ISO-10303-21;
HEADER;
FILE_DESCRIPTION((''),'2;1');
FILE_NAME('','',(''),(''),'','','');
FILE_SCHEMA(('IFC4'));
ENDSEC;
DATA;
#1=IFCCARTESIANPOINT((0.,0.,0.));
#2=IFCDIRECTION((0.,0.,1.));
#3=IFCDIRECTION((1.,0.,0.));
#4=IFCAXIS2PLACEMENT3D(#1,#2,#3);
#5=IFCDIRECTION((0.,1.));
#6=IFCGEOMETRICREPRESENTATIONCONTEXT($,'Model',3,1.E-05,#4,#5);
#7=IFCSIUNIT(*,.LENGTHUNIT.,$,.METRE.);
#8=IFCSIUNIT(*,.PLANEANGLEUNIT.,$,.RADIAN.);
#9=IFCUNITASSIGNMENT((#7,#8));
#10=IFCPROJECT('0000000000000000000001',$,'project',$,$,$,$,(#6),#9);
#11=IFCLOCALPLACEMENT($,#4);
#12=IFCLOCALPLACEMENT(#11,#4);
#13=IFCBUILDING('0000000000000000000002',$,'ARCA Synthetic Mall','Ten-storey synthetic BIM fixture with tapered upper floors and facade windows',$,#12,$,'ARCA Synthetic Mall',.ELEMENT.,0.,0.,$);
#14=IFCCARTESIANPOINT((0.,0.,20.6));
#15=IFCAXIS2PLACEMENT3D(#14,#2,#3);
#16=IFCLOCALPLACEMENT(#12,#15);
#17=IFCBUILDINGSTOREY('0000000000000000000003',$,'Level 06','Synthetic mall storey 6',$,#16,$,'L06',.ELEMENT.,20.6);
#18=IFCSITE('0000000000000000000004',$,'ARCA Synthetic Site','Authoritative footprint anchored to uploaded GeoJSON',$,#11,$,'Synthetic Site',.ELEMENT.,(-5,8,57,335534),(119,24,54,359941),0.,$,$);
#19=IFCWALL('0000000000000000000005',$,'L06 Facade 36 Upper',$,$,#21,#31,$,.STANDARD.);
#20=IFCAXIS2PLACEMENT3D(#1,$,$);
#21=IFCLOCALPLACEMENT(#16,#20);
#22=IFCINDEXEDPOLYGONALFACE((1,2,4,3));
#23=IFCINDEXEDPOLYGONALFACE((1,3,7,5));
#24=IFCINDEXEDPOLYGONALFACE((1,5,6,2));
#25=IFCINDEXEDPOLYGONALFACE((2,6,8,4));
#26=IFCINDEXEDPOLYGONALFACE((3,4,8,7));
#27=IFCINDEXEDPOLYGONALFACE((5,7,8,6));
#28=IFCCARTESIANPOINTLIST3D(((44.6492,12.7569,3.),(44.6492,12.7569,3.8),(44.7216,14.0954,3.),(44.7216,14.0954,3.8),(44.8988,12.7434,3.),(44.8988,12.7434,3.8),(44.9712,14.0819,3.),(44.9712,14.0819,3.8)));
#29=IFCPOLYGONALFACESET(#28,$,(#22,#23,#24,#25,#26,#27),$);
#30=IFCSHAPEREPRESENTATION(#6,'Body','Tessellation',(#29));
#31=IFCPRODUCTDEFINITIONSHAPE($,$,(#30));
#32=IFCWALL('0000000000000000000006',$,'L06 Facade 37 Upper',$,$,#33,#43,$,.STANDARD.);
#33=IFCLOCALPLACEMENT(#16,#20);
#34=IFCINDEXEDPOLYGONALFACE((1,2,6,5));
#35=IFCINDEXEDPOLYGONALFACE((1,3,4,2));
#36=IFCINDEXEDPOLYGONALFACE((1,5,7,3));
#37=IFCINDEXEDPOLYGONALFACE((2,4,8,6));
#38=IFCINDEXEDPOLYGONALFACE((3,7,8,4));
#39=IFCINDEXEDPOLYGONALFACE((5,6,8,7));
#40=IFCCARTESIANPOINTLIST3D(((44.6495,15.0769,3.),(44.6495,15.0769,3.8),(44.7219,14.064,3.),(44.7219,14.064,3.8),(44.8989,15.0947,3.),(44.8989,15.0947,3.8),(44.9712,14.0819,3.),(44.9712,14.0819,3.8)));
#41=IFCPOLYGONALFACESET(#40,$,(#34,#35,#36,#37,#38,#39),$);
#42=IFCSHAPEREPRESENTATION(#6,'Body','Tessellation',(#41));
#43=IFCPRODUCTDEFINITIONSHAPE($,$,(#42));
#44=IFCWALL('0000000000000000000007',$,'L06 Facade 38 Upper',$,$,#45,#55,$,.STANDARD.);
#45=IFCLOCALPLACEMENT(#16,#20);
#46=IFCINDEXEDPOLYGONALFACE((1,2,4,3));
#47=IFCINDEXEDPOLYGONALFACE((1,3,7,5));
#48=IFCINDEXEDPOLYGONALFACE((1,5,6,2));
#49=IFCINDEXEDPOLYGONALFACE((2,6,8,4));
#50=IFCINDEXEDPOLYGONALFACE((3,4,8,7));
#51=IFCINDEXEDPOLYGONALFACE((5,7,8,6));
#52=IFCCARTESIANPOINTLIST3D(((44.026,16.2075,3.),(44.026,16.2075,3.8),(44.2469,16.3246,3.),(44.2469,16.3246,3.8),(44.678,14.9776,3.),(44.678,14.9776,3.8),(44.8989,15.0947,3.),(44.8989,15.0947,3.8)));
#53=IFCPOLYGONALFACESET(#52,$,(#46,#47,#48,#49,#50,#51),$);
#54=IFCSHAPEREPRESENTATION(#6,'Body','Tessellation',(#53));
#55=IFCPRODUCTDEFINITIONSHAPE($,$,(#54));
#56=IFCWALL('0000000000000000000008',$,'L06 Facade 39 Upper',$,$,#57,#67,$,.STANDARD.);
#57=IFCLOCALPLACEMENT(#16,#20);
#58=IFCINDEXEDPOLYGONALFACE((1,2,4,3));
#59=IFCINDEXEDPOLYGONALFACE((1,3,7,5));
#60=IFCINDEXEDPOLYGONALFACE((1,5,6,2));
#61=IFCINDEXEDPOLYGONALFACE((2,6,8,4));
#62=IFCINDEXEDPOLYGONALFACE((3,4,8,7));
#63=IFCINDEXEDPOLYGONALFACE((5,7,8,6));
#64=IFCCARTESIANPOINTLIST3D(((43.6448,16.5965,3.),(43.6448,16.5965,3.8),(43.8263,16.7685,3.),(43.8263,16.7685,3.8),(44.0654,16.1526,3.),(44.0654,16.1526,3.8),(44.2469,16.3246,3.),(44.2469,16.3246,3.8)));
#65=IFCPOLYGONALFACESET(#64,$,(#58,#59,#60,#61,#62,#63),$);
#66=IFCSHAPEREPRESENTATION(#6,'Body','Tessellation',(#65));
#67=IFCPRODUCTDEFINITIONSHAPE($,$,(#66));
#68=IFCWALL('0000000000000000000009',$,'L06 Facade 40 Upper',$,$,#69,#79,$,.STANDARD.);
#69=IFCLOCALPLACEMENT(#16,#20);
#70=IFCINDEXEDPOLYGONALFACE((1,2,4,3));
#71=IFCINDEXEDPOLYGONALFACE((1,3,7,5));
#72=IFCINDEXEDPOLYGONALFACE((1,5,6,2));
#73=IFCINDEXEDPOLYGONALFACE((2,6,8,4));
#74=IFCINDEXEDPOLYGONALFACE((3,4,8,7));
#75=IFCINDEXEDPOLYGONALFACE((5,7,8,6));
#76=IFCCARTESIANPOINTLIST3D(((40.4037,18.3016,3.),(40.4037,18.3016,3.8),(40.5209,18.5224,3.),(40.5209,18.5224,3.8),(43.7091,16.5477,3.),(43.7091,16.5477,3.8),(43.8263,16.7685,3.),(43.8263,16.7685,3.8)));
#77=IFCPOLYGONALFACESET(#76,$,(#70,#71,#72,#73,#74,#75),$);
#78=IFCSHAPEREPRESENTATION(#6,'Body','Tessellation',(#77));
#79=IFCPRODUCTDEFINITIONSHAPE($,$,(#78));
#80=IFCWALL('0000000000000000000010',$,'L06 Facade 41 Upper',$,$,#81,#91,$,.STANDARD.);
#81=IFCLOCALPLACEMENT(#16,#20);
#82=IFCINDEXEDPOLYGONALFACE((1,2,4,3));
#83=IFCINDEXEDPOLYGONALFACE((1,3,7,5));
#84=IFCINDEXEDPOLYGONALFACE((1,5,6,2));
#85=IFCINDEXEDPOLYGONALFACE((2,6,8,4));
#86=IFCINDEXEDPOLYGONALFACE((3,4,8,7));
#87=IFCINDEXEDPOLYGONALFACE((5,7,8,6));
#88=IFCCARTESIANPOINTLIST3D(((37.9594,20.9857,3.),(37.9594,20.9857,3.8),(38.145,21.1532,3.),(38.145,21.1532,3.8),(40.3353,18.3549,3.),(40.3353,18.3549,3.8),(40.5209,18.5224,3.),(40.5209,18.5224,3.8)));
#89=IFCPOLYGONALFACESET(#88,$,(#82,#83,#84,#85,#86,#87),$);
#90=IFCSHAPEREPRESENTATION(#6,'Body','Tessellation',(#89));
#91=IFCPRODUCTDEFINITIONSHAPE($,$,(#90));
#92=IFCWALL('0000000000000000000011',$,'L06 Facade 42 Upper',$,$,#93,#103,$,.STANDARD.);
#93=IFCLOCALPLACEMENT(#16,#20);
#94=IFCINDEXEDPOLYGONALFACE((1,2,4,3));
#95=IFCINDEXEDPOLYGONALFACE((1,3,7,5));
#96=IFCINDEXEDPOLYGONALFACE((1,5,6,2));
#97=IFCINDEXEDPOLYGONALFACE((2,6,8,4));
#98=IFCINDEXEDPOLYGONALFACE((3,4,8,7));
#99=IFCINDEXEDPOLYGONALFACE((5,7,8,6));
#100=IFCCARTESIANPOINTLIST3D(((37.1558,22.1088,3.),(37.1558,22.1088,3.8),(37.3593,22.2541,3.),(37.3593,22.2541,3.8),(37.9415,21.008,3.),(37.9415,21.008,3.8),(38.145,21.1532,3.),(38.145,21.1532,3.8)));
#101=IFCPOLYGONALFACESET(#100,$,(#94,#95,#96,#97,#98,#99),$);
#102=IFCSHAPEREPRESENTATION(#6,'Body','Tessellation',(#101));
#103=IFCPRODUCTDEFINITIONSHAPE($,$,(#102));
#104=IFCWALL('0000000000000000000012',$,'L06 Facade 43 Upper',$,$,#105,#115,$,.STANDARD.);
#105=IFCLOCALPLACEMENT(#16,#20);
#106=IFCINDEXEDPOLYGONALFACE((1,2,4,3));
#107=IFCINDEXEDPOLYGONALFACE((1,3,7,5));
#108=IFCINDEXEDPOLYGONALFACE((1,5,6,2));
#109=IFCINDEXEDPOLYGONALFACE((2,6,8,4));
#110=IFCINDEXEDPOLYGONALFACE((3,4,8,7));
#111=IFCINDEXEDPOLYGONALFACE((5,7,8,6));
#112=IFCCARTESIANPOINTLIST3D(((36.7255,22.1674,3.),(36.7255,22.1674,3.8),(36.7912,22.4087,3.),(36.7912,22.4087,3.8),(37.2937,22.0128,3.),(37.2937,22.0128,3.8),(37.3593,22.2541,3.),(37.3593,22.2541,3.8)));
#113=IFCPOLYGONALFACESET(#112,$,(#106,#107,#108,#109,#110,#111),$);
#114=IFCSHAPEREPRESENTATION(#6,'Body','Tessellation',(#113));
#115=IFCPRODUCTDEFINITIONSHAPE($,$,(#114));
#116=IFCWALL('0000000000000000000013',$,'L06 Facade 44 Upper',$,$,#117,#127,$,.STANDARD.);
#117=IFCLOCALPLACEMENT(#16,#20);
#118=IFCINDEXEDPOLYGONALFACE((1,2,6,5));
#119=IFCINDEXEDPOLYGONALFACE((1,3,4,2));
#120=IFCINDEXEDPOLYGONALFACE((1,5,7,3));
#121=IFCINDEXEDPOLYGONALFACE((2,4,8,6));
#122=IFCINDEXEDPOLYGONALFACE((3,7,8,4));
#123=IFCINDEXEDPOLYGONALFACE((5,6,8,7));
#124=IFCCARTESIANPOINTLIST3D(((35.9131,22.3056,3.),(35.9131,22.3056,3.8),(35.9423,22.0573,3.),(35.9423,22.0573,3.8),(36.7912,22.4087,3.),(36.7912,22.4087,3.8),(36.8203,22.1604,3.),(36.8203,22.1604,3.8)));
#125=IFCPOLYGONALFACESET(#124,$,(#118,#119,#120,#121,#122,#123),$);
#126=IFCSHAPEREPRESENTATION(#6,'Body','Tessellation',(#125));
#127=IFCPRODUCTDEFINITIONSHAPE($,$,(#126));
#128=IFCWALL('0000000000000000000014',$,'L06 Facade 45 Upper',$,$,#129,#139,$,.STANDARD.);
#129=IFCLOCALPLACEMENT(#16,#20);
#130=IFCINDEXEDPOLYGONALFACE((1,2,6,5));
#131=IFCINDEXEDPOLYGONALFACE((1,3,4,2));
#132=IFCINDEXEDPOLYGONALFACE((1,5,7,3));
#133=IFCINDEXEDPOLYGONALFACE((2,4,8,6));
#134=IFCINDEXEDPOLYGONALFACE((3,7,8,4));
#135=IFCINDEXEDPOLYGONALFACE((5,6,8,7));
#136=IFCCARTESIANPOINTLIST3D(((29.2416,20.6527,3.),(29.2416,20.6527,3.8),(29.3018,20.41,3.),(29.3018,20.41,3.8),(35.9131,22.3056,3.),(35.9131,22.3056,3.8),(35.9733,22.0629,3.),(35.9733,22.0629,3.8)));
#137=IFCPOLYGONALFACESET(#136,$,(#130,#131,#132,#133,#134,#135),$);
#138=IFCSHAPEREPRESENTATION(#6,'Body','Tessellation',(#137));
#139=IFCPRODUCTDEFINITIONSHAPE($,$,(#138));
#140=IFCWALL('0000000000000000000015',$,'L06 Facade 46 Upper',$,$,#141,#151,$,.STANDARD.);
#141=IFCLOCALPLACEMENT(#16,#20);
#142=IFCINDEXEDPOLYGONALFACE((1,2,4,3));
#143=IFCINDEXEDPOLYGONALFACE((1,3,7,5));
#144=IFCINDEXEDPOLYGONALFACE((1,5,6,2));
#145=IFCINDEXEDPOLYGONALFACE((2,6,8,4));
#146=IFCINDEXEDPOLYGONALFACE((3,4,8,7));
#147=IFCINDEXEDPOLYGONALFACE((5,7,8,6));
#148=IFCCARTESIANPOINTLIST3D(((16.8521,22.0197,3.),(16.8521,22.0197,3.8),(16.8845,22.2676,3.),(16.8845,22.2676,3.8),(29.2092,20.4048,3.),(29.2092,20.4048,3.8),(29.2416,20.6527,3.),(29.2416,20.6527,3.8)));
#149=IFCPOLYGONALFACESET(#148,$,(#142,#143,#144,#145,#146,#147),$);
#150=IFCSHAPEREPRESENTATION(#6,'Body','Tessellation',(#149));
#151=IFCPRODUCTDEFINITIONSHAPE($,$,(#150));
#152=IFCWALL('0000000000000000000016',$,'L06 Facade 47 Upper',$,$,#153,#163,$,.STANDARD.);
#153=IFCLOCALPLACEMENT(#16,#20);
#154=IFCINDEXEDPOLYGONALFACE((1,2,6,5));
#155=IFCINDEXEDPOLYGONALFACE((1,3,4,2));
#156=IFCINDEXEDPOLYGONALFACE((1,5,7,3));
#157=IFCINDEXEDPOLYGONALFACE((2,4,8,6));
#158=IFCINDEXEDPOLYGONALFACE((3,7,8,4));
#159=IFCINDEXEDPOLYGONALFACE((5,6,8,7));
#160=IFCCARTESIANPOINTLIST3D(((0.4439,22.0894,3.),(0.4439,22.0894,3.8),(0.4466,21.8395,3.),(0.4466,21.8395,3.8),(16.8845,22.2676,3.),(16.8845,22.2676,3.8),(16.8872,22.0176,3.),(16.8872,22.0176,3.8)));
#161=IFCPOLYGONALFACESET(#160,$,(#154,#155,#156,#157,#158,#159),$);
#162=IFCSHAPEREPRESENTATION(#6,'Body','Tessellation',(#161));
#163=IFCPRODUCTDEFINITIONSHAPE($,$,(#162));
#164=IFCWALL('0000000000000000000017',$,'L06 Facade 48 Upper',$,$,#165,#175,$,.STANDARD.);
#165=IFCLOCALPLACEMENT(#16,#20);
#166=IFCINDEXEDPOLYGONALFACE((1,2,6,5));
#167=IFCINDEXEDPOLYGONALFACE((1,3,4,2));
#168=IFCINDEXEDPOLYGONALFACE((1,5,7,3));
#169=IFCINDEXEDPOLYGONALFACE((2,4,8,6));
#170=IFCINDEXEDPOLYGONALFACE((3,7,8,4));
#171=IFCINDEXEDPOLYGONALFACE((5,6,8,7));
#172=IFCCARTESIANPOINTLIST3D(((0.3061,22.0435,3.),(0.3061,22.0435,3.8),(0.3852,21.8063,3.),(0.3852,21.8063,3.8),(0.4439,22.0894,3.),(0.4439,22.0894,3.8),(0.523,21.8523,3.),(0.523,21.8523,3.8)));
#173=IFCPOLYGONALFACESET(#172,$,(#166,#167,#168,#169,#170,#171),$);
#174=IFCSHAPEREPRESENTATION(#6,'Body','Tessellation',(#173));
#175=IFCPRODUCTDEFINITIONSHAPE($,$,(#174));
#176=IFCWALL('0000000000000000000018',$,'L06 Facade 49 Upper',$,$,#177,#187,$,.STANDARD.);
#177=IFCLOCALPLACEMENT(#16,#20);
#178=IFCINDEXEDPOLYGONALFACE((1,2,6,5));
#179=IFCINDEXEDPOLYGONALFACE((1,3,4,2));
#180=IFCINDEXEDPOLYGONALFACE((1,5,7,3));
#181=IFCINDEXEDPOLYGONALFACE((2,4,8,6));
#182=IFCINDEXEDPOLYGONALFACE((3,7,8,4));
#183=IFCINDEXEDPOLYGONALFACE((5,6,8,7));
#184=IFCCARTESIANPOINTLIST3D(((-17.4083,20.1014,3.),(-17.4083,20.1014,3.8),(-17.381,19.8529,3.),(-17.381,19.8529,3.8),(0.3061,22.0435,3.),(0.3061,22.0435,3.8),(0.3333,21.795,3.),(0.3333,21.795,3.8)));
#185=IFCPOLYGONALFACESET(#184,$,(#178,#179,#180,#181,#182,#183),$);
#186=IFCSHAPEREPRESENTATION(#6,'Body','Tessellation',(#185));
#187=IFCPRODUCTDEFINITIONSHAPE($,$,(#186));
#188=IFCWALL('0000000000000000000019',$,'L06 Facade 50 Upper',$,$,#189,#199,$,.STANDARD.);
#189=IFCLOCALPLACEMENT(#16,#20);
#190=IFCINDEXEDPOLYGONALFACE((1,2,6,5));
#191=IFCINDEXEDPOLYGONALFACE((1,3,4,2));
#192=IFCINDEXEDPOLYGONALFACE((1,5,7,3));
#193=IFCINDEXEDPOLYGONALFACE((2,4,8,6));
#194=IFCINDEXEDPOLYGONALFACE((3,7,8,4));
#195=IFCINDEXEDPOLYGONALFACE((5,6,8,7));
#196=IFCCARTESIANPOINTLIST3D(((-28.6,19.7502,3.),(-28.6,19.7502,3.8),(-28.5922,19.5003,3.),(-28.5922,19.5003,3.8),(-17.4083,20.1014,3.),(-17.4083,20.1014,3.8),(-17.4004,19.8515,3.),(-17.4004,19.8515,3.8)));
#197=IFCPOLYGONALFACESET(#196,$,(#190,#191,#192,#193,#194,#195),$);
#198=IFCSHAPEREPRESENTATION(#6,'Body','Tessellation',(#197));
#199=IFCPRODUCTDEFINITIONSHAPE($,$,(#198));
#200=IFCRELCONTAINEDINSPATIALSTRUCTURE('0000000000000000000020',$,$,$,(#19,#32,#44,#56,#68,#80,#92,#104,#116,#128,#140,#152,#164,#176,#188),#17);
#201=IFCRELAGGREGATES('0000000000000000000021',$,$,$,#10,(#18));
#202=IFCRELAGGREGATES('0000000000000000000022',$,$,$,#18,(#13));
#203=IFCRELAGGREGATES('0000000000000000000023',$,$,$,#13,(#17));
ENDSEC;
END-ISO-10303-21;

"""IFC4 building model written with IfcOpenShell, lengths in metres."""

from ifc_helpers import new_model, si_unit, direction, frame, origin_with_axes, place, context, project, spatial, polyline, outline, extrude, element, save


model = new_model("IFC4")

# Units and contexts
model_context = context("Model", 3, precision=1e-05, world=origin_with_axes(), true_north=direction((0.0, 1.0)))
ifc_project = project(units=[si_unit("LENGTHUNIT", "METRE"), si_unit("PLANEANGLEUNIT", "RADIAN")], contexts=[model_context])

# Site, building, storey
site_placement = place(None, origin_with_axes())
site = spatial("IfcSite", under=ifc_project, at=site_placement, Name="ARCA Synthetic Site", Description="Authoritative footprint anchored to uploaded GeoJSON", LongName="Synthetic Site", CompositionType="ELEMENT", RefLatitude=(-5, 8, 57, 335534), RefLongitude=(119, 24, 54, 359941), RefElevation=0.0)
building_placement = place(site_placement, origin_with_axes())
building = spatial("IfcBuilding", under=site, at=building_placement, Name="ARCA Synthetic Mall", Description="Ten-storey synthetic BIM fixture with tapered upper floors and facade windows", LongName="ARCA Synthetic Mall", CompositionType="ELEMENT", ElevationOfRefHeight=0.0, ElevationOfTerrain=0.0)
storey_placement = place(building_placement, frame((0.0, 0.0, 20.6), z_axis=(0.0, 0.0, 1.0), x_axis=(1.0, 0.0, 0.0)))
storey = spatial("IfcBuildingStorey", under=building, at=storey_placement, Name="Level 06", Description="Synthetic mall storey 6", LongName="L06", CompositionType="ELEMENT", Elevation=20.6)

# Walls
wall_1_placement = place(storey_placement, frame((0.0, 0.0, 3.0), z_axis=(0.0, 0.0, 1.0), x_axis=(1.0, 0.0, 0.0)))
element("IfcWall", 1, at=wall_1_placement, inside=storey, Name="L06 Facade 36 Upper", PredefinedType="STANDARD", context=model_context, shape_type="SweptSolid", body=[
    extrude(outline(polyline([(44.8988, 12.7434), (44.9712, 14.0819), (44.7216, 14.0954), (44.6492, 12.7569), (44.8988, 12.7434)])), origin_with_axes(), (0.0, 0.0, 1.0), 0.8),
])
wall_2_placement = place(storey_placement, frame((0.0, 0.0, 3.0), z_axis=(0.0, 0.0, 1.0), x_axis=(1.0, 0.0, 0.0)))
element("IfcWall", 2, at=wall_2_placement, inside=storey, Name="L06 Facade 37 Upper", PredefinedType="STANDARD", context=model_context, shape_type="SweptSolid", body=[
    extrude(outline(polyline([(44.9712, 14.0819), (44.8989, 15.0947), (44.6495, 15.0769), (44.7219, 14.064), (44.9712, 14.0819)])), origin_with_axes(), (0.0, 0.0, 1.0), 0.8),
])
wall_3_placement = place(storey_placement, frame((0.0, 0.0, 3.0), z_axis=(0.0, 0.0, 1.0), x_axis=(1.0, 0.0, 0.0)))
element("IfcWall", 3, at=wall_3_placement, inside=storey, Name="L06 Facade 38 Upper", PredefinedType="STANDARD", context=model_context, shape_type="SweptSolid", body=[
    extrude(outline(polyline([(44.8989, 15.0947), (44.2469, 16.3246), (44.026, 16.2075), (44.678, 14.9776), (44.8989, 15.0947)])), origin_with_axes(), (0.0, 0.0, 1.0), 0.8),
])
wall_4_placement = place(storey_placement, frame((0.0, 0.0, 3.0), z_axis=(0.0, 0.0, 1.0), x_axis=(1.0, 0.0, 0.0)))
element("IfcWall", 4, at=wall_4_placement, inside=storey, Name="L06 Facade 39 Upper", PredefinedType="STANDARD", context=model_context, shape_type="SweptSolid", body=[
    extrude(outline(polyline([(44.2469, 16.3246), (43.8263, 16.7685), (43.6448, 16.5965), (44.0654, 16.1526), (44.2469, 16.3246)])), origin_with_axes(), (0.0, 0.0, 1.0), 0.8),
])
wall_5_placement = place(storey_placement, frame((0.0, 0.0, 3.0), z_axis=(0.0, 0.0, 1.0), x_axis=(1.0, 0.0, 0.0)))
element("IfcWall", 5, at=wall_5_placement, inside=storey, Name="L06 Facade 40 Upper", PredefinedType="STANDARD", context=model_context, shape_type="SweptSolid", body=[
    extrude(outline(polyline([(43.8263, 16.7685), (40.5209, 18.5224), (40.4037, 18.3016), (43.7091, 16.5477), (43.8263, 16.7685)])), origin_with_axes(), (0.0, 0.0, 1.0), 0.8),
])
wall_6_placement = place(storey_placement, frame((0.0, 0.0, 3.0), z_axis=(0.0, 0.0, 1.0), x_axis=(1.0, 0.0, 0.0)))
element("IfcWall", 6, at=wall_6_placement, inside=storey, Name="L06 Facade 41 Upper", PredefinedType="STANDARD", context=model_context, shape_type="SweptSolid", body=[
    extrude(outline(polyline([(40.5209, 18.5224), (38.145, 21.1532), (37.9594, 20.9857), (40.3353, 18.3549), (40.5209, 18.5224)])), origin_with_axes(), (0.0, 0.0, 1.0), 0.8),
])
wall_7_placement = place(storey_placement, frame((0.0, 0.0, 3.0), z_axis=(0.0, 0.0, 1.0), x_axis=(1.0, 0.0, 0.0)))
element("IfcWall", 7, at=wall_7_placement, inside=storey, Name="L06 Facade 42 Upper", PredefinedType="STANDARD", context=model_context, shape_type="SweptSolid", body=[
    extrude(outline(polyline([(38.145, 21.1532), (37.3593, 22.2541), (37.1558, 22.1088), (37.9415, 21.008), (38.145, 21.1532)])), origin_with_axes(), (0.0, 0.0, 1.0), 0.8),
])
wall_8_placement = place(storey_placement, frame((0.0, 0.0, 3.0), z_axis=(0.0, 0.0, 1.0), x_axis=(1.0, 0.0, 0.0)))
element("IfcWall", 8, at=wall_8_placement, inside=storey, Name="L06 Facade 43 Upper", PredefinedType="STANDARD", context=model_context, shape_type="SweptSolid", body=[
    extrude(outline(polyline([(37.3593, 22.2541), (36.7912, 22.4087), (36.7255, 22.1674), (37.2937, 22.0128), (37.3593, 22.2541)])), origin_with_axes(), (0.0, 0.0, 1.0), 0.8),
])
wall_9_placement = place(storey_placement, frame((0.0, 0.0, 3.0), z_axis=(0.0, 0.0, 1.0), x_axis=(1.0, 0.0, 0.0)))
element("IfcWall", 9, at=wall_9_placement, inside=storey, Name="L06 Facade 44 Upper", PredefinedType="STANDARD", context=model_context, shape_type="SweptSolid", body=[
    extrude(outline(polyline([(36.7912, 22.4087), (35.9131, 22.3056), (35.9423, 22.0573), (36.8203, 22.1604), (36.7912, 22.4087)])), origin_with_axes(), (0.0, 0.0, 1.0), 0.8),
])
wall_10_placement = place(storey_placement, frame((0.0, 0.0, 3.0), z_axis=(0.0, 0.0, 1.0), x_axis=(1.0, 0.0, 0.0)))
element("IfcWall", 10, at=wall_10_placement, inside=storey, Name="L06 Facade 45 Upper", PredefinedType="STANDARD", context=model_context, shape_type="SweptSolid", body=[
    extrude(outline(polyline([(35.9131, 22.3056), (29.2416, 20.6527), (29.3018, 20.41), (35.9733, 22.0629), (35.9131, 22.3056)])), origin_with_axes(), (0.0, 0.0, 1.0), 0.8),
])
wall_11_placement = place(storey_placement, frame((0.0, 0.0, 3.0), z_axis=(0.0, 0.0, 1.0), x_axis=(1.0, 0.0, 0.0)))
element("IfcWall", 11, at=wall_11_placement, inside=storey, Name="L06 Facade 46 Upper", PredefinedType="STANDARD", context=model_context, shape_type="SweptSolid", body=[
    extrude(outline(polyline([(29.2416, 20.6527), (16.8845, 22.2676), (16.8521, 22.0197), (29.2092, 20.4048), (29.2416, 20.6527)])), origin_with_axes(), (0.0, 0.0, 1.0), 0.8),
])
wall_12_placement = place(storey_placement, frame((0.0, 0.0, 3.0), z_axis=(0.0, 0.0, 1.0), x_axis=(1.0, 0.0, 0.0)))
element("IfcWall", 12, at=wall_12_placement, inside=storey, Name="L06 Facade 47 Upper", PredefinedType="STANDARD", context=model_context, shape_type="SweptSolid", body=[
    extrude(outline(polyline([(16.8845, 22.2676), (0.4439, 22.0894), (0.4466, 21.8395), (16.8872, 22.0176), (16.8845, 22.2676)])), origin_with_axes(), (0.0, 0.0, 1.0), 0.8),
])
wall_13_placement = place(storey_placement, frame((0.0, 0.0, 3.0), z_axis=(0.0, 0.0, 1.0), x_axis=(1.0, 0.0, 0.0)))
element("IfcWall", 13, at=wall_13_placement, inside=storey, Name="L06 Facade 48 Upper", PredefinedType="STANDARD", context=model_context, shape_type="SweptSolid", body=[
    extrude(outline(polyline([(0.4439, 22.0894), (0.3061, 22.0435), (0.3852, 21.8063), (0.523, 21.8523), (0.4439, 22.0894)])), origin_with_axes(), (0.0, 0.0, 1.0), 0.8),
])
wall_14_placement = place(storey_placement, frame((0.0, 0.0, 3.0), z_axis=(0.0, 0.0, 1.0), x_axis=(1.0, 0.0, 0.0)))
element("IfcWall", 14, at=wall_14_placement, inside=storey, Name="L06 Facade 49 Upper", PredefinedType="STANDARD", context=model_context, shape_type="SweptSolid", body=[
    extrude(outline(polyline([(0.3061, 22.0435), (-17.4083, 20.1014), (-17.381, 19.8529), (0.3333, 21.795), (0.3061, 22.0435)])), origin_with_axes(), (0.0, 0.0, 1.0), 0.8),
])
wall_15_placement = place(storey_placement, frame((0.0, 0.0, 3.0), z_axis=(0.0, 0.0, 1.0), x_axis=(1.0, 0.0, 0.0)))
element("IfcWall", 15, at=wall_15_placement, inside=storey, Name="L06 Facade 50 Upper", PredefinedType="STANDARD", context=model_context, shape_type="SweptSolid", body=[
    extrude(outline(polyline([(-17.4083, 20.1014), (-28.6, 19.7502), (-28.5922, 19.5003), (-17.4004, 19.8515), (-17.4083, 20.1014)])), origin_with_axes(), (0.0, 0.0, 1.0), 0.8),
])

save(model, "model.ifc")
